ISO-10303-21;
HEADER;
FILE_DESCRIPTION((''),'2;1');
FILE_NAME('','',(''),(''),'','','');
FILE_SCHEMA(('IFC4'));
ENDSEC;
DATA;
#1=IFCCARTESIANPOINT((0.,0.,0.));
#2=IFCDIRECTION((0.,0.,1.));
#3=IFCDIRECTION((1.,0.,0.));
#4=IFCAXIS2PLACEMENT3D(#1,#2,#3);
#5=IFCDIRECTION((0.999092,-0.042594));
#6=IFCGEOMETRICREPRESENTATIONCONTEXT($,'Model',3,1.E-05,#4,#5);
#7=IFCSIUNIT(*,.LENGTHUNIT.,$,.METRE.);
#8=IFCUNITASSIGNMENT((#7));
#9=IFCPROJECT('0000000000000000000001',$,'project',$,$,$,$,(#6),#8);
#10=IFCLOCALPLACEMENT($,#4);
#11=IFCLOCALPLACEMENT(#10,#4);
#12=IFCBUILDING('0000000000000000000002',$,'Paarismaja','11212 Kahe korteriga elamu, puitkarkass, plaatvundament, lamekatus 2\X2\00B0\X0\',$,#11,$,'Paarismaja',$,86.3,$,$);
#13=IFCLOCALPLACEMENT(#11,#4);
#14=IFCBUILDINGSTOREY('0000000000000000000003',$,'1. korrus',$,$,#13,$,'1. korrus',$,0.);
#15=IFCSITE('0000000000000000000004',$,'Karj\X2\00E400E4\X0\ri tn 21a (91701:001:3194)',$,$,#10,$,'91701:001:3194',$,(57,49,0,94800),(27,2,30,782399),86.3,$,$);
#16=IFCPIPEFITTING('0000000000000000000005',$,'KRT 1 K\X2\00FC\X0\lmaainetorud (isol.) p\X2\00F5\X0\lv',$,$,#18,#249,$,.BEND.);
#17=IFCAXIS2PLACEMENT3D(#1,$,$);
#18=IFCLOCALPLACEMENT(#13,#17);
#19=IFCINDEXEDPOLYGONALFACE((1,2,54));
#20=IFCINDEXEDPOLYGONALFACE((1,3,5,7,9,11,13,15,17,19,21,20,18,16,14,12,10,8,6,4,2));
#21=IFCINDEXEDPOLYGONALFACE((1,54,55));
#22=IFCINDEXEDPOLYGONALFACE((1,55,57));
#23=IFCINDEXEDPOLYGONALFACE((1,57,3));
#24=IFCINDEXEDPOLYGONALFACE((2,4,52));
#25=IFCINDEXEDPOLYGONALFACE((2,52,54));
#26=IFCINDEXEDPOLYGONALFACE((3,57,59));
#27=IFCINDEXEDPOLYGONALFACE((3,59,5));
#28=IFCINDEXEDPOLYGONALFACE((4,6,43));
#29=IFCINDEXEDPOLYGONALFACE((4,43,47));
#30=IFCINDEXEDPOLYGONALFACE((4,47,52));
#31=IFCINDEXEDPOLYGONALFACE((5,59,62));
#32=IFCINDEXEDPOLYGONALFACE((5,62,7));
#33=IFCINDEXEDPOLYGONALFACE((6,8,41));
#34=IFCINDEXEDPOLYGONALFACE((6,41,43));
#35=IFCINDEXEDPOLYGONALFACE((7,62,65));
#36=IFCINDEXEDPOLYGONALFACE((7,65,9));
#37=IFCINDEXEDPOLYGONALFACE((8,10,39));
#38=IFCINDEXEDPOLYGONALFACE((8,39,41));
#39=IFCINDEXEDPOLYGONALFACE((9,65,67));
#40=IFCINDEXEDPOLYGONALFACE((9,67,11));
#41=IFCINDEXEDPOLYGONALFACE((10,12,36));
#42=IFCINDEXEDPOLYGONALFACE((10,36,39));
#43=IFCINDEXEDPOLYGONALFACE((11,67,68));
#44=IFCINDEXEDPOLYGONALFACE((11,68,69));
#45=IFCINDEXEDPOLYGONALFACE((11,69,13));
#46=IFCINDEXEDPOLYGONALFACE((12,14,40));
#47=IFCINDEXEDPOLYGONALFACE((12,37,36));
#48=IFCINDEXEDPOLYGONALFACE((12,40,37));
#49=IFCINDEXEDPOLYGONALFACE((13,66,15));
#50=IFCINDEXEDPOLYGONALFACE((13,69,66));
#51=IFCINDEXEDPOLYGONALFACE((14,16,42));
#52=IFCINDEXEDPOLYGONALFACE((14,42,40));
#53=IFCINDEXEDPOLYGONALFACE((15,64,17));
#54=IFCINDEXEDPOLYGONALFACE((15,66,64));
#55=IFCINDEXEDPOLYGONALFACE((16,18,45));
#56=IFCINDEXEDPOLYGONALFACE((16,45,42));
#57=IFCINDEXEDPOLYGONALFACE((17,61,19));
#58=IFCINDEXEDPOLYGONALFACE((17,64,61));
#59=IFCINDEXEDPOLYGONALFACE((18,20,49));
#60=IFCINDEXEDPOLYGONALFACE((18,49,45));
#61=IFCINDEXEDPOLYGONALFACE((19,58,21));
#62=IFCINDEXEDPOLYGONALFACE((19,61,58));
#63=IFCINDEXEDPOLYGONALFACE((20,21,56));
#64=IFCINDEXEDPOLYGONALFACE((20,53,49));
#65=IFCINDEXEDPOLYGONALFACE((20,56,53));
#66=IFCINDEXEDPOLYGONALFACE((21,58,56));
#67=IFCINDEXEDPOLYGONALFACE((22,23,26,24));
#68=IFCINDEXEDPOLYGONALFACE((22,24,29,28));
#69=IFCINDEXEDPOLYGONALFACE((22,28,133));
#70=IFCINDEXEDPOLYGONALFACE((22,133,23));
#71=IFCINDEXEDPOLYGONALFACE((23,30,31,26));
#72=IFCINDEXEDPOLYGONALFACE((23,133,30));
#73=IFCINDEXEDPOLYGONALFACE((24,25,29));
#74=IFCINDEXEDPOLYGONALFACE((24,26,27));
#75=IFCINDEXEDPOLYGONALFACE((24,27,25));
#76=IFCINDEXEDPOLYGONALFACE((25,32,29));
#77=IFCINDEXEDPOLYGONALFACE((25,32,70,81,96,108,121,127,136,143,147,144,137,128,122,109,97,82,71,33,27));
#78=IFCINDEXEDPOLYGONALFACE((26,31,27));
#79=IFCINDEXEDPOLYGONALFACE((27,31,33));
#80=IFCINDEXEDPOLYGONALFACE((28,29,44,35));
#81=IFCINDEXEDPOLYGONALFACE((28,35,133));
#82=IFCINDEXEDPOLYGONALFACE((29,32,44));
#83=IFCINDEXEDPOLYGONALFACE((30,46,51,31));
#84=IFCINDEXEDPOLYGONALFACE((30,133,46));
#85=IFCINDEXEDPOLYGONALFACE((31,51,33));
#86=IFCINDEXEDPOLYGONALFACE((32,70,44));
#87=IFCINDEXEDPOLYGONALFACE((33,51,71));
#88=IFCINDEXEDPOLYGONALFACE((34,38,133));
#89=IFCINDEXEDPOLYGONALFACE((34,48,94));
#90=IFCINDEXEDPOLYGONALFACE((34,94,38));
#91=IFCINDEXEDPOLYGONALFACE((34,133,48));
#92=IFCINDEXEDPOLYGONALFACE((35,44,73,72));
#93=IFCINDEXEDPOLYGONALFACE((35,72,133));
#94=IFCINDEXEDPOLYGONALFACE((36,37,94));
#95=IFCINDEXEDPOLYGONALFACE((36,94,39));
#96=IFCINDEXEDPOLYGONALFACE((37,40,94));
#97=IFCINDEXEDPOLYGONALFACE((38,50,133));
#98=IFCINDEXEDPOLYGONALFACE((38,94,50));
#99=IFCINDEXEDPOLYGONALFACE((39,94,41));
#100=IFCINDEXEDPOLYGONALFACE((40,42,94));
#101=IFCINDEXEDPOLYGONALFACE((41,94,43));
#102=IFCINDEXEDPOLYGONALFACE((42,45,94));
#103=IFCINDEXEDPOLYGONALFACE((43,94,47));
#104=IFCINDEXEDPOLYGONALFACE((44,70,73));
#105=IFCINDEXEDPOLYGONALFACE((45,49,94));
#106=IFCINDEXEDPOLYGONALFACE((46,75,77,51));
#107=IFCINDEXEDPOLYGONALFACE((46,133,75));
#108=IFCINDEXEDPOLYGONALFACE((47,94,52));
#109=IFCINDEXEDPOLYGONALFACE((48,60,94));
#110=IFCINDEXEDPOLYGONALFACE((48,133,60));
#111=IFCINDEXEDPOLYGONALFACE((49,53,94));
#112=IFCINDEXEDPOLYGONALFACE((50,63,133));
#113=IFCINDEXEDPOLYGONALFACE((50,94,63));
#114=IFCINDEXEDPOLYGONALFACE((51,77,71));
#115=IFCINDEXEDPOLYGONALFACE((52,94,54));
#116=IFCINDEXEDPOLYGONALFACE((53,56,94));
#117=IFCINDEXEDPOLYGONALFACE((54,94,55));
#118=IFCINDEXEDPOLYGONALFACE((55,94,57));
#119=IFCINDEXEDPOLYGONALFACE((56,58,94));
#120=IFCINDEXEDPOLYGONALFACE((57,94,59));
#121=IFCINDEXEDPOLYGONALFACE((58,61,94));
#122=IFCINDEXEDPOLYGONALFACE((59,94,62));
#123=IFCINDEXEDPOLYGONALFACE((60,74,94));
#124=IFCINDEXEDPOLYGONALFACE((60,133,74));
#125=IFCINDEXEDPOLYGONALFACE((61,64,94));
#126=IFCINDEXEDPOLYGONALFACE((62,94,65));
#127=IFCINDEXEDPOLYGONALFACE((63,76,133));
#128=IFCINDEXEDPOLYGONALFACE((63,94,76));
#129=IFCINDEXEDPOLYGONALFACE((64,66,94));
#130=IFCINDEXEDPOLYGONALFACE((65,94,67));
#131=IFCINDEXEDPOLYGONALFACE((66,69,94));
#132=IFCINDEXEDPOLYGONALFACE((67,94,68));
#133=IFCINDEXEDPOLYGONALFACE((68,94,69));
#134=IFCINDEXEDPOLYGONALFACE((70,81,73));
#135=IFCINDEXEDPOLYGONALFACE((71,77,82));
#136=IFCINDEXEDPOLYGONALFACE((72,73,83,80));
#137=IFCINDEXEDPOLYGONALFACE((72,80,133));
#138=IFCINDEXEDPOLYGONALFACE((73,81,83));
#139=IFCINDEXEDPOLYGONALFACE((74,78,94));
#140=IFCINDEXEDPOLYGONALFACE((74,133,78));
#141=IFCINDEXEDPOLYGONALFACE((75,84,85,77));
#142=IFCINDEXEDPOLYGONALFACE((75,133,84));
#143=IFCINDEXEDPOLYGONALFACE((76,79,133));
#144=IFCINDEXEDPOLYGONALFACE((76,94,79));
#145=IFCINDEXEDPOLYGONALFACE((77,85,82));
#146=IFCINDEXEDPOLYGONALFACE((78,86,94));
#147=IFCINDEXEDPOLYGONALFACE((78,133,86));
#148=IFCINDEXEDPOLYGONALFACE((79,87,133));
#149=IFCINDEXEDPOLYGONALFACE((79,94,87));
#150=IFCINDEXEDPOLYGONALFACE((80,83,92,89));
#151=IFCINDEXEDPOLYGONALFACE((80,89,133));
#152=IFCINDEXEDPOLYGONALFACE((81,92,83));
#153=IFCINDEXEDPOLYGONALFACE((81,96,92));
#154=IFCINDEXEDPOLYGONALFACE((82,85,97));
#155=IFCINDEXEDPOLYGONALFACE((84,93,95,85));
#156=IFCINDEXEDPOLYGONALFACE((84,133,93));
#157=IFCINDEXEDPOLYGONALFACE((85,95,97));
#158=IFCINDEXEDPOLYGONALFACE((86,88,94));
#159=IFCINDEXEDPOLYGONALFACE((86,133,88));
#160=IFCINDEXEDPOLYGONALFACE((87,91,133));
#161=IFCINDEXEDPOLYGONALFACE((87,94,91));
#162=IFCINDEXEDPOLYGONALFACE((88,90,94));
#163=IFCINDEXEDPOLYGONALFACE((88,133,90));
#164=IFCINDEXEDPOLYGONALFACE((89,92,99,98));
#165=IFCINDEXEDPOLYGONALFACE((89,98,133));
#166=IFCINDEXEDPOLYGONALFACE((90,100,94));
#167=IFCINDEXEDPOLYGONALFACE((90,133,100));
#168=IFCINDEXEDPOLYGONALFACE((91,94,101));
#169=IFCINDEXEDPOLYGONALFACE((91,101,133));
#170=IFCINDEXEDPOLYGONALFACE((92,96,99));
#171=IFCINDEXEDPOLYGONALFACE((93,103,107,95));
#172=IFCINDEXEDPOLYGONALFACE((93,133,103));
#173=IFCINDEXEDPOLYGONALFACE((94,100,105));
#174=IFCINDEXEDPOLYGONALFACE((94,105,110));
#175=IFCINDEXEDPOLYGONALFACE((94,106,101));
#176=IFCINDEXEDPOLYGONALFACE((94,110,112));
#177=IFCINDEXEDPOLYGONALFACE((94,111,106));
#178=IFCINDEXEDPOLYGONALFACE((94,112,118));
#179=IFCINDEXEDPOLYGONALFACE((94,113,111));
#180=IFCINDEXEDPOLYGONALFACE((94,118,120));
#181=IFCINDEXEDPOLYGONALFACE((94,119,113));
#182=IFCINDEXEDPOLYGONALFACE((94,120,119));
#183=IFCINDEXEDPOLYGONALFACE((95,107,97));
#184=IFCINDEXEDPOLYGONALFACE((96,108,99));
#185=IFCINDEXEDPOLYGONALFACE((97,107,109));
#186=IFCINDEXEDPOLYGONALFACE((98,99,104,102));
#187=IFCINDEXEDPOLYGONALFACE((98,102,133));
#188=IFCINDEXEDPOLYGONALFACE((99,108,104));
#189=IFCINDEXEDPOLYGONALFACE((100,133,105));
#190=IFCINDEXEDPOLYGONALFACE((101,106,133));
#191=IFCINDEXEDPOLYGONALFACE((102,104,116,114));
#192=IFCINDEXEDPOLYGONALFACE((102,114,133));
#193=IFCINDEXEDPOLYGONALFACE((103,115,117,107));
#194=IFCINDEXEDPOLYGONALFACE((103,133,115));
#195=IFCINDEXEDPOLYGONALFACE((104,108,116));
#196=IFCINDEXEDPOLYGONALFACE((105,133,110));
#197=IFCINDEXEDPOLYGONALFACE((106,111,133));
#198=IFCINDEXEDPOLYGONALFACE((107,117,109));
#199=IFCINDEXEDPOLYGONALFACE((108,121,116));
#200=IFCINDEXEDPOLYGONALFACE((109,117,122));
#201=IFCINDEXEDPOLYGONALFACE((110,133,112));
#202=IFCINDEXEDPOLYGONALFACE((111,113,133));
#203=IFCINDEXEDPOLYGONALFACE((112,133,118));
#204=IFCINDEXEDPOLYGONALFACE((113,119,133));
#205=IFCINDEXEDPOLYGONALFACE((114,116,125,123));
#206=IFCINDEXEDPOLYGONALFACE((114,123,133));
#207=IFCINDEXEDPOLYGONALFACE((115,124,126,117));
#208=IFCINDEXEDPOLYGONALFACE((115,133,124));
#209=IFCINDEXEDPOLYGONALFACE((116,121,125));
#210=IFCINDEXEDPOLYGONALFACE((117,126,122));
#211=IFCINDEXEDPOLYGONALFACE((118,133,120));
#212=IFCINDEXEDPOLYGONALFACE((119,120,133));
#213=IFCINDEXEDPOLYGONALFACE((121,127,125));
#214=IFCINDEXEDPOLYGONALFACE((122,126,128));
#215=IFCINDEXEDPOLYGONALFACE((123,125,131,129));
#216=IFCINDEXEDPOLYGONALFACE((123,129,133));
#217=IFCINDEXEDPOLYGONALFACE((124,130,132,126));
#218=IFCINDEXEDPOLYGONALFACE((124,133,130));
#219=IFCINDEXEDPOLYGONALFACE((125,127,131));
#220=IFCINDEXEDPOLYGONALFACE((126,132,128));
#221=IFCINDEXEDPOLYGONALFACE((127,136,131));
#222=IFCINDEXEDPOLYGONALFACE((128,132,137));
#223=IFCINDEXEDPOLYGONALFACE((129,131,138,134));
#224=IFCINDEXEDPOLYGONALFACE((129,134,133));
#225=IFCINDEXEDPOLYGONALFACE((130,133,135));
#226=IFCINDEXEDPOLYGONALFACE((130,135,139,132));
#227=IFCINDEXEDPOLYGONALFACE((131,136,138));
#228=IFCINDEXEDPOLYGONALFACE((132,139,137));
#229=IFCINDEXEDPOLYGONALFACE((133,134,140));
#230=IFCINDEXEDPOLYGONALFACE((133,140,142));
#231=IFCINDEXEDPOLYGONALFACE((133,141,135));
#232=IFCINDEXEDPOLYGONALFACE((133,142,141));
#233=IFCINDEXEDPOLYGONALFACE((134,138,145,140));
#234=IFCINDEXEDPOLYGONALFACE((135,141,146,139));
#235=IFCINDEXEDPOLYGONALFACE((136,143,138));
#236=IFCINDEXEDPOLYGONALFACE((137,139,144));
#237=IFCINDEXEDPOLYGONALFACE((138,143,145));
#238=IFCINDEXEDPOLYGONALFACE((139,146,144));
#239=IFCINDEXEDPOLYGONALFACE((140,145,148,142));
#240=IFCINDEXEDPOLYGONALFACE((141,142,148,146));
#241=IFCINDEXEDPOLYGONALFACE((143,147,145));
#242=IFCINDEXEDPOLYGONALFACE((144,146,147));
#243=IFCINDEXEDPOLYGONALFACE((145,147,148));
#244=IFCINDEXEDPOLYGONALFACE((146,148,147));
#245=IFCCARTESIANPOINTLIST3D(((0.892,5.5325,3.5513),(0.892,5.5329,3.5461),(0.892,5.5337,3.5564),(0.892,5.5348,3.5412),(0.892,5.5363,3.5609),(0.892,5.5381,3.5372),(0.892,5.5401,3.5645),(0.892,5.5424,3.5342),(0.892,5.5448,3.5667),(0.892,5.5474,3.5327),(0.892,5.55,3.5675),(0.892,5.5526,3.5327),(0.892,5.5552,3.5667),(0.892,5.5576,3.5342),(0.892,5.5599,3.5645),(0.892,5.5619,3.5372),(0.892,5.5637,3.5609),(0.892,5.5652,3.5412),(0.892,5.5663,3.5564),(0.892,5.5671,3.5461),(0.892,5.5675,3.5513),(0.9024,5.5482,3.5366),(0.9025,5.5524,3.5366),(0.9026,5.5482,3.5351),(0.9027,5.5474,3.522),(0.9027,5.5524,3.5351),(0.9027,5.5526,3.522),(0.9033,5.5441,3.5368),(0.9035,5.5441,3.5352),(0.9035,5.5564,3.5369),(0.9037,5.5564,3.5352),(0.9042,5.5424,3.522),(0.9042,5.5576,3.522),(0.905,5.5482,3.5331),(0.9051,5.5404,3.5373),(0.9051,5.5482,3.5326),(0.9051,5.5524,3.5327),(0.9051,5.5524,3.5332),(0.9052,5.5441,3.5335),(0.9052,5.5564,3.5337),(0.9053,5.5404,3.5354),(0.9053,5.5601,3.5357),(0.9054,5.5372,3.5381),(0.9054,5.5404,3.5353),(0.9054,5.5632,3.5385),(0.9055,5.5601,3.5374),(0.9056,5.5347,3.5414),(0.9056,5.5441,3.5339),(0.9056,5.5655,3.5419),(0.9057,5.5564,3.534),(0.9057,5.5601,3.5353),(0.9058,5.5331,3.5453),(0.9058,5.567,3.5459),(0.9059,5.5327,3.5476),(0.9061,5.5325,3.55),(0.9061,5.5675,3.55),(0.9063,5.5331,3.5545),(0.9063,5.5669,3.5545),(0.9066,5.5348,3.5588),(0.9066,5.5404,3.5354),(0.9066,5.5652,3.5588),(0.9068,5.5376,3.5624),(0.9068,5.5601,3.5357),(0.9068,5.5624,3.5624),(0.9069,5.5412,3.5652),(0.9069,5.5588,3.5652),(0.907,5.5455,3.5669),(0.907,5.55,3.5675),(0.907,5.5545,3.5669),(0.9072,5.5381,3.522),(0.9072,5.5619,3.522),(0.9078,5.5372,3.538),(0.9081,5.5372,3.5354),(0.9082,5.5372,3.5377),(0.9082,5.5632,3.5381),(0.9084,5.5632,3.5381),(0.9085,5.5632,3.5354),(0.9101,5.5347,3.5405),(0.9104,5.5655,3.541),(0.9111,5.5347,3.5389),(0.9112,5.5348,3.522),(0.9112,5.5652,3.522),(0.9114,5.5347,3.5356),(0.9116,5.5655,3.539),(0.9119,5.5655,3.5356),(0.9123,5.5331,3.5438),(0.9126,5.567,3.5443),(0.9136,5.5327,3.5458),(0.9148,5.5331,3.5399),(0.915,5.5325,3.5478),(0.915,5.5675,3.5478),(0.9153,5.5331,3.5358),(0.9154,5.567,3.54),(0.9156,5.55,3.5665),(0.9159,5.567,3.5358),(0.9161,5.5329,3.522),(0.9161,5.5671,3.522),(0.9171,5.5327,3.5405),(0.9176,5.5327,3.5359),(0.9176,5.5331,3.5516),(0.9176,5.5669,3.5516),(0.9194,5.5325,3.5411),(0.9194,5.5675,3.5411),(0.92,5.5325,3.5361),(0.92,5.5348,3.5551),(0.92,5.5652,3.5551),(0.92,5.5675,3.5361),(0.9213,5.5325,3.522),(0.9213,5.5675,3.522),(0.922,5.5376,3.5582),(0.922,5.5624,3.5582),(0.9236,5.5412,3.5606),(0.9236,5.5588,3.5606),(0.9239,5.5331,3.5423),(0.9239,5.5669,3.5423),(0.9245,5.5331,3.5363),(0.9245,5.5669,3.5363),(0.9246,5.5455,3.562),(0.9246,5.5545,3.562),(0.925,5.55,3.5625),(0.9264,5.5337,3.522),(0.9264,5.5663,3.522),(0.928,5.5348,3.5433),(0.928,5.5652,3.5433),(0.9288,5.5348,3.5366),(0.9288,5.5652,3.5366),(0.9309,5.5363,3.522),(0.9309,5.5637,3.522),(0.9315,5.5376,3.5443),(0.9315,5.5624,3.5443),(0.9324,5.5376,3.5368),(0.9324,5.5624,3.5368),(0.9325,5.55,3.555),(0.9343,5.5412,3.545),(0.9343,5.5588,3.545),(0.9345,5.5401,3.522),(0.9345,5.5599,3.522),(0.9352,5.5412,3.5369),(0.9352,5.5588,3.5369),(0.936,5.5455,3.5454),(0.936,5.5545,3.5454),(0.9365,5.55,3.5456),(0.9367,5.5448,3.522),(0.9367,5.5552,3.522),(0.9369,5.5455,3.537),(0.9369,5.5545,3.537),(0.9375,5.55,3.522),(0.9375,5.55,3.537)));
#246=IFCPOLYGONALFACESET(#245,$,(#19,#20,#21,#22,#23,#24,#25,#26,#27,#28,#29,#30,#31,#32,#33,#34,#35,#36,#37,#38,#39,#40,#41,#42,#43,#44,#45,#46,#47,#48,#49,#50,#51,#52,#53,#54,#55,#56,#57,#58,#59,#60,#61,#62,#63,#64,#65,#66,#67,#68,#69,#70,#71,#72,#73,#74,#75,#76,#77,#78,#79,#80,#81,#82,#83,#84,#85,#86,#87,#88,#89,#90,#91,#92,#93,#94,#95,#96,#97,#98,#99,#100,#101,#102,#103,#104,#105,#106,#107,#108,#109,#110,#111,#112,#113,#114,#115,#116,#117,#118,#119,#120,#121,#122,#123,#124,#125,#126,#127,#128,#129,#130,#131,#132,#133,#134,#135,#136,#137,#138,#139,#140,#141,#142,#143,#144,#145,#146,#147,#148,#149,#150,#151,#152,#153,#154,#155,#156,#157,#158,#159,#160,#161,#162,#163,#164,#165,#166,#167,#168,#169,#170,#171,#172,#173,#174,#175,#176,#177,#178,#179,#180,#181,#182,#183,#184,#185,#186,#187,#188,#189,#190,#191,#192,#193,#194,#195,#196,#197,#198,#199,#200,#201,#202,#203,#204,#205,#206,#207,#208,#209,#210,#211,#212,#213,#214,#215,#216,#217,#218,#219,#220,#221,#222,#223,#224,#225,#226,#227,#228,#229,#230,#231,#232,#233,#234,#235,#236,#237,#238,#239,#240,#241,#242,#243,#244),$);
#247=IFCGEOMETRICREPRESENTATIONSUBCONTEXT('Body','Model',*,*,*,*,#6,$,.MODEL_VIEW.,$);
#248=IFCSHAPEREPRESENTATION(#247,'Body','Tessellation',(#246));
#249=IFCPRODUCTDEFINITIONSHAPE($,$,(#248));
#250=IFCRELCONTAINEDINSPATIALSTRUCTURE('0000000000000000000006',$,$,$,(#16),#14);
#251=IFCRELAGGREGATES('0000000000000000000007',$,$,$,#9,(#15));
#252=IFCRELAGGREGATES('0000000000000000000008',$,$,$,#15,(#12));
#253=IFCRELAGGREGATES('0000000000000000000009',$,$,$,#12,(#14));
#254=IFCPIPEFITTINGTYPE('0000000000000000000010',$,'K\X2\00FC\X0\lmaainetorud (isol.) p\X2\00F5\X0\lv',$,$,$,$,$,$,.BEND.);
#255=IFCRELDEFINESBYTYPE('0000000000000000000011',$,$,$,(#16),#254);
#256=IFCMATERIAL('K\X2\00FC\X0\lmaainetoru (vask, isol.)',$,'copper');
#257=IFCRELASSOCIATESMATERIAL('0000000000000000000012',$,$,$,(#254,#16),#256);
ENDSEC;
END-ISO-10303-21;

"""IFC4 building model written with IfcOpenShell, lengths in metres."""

from ifc_helpers import new_model, entity, si_unit, direction, frame, origin_with_axes, place, context, subcontext, project, spatial, material, type_object, element, save


model = new_model("IFC4")

# Units and contexts
model_context = context("Model", 3, precision=1e-05, world=origin_with_axes(), true_north=direction((0.999092, -0.042594)))
body_context = subcontext(model_context, "Body", "Model", "MODEL_VIEW")
ifc_project = project(units=[si_unit("LENGTHUNIT", "METRE")], contexts=[model_context])

# Site, building, storey
site_placement = place(None, origin_with_axes())
site = spatial("IfcSite", under=ifc_project, at=site_placement, Name="Karjääri tn 21a (91701:001:3194)", LongName="91701:001:3194", RefLatitude=(57, 49, 0, 94800), RefLongitude=(27, 2, 30, 782399), RefElevation=86.3)
building_placement = place(site_placement, origin_with_axes())
building = spatial("IfcBuilding", under=site, at=building_placement, Name="Paarismaja", Description="11212 Kahe korteriga elamu, puitkarkass, plaatvundament, lamekatus 2°", LongName="Paarismaja", ElevationOfRefHeight=86.3)
storey_placement = place(building_placement, origin_with_axes())
storey = spatial("IfcBuildingStorey", under=building, at=storey_placement, Name="1. korrus", LongName="1. korrus", Elevation=0.0)

# Pipe fitting
ifc_material_1 = material(Name="Külmaainetoru (vask, isol.)", Category="copper")
pipe_fitting_type_1 = type_object("IfcPipeFittingType", Name="Külmaainetorud (isol.) põlv", PredefinedType="BEND", material=ifc_material_1)
pipe_fitting_1_placement = place(storey_placement, frame((0.92, 5.55, 3.55), z_axis=(0.0, 0.0, 1.0), x_axis=(1.0, 0.0, 0.0)))
element("IfcPipeFitting", 1, at=pipe_fitting_1_placement, inside=storey, type_object=pipe_fitting_type_1, material=ifc_material_1, Name="KRT 1 Külmaainetorud (isol.) põlv", PredefinedType="BEND", context=body_context, shape_type="AdvancedSweptSolid", body=[
    entity("IfcSweptDiskSolid", entity("IfcIndexedPolyCurve", entity("IfcCartesianPointList3D", [[0.0, 0.0, -0.028], [0.0, 0.0, -0.0139], [-0.0006, 0.0, -0.0089], [-0.0022, 0.0, -0.005], [-0.005, 0.0, -0.0022], [-0.0089, 0.0, -0.0006], [-0.0139, 0.0, 0.0], [-0.028, 0.0, 0.0]]), None, False), 0.0175),
])

save(model, "model.ifc")
